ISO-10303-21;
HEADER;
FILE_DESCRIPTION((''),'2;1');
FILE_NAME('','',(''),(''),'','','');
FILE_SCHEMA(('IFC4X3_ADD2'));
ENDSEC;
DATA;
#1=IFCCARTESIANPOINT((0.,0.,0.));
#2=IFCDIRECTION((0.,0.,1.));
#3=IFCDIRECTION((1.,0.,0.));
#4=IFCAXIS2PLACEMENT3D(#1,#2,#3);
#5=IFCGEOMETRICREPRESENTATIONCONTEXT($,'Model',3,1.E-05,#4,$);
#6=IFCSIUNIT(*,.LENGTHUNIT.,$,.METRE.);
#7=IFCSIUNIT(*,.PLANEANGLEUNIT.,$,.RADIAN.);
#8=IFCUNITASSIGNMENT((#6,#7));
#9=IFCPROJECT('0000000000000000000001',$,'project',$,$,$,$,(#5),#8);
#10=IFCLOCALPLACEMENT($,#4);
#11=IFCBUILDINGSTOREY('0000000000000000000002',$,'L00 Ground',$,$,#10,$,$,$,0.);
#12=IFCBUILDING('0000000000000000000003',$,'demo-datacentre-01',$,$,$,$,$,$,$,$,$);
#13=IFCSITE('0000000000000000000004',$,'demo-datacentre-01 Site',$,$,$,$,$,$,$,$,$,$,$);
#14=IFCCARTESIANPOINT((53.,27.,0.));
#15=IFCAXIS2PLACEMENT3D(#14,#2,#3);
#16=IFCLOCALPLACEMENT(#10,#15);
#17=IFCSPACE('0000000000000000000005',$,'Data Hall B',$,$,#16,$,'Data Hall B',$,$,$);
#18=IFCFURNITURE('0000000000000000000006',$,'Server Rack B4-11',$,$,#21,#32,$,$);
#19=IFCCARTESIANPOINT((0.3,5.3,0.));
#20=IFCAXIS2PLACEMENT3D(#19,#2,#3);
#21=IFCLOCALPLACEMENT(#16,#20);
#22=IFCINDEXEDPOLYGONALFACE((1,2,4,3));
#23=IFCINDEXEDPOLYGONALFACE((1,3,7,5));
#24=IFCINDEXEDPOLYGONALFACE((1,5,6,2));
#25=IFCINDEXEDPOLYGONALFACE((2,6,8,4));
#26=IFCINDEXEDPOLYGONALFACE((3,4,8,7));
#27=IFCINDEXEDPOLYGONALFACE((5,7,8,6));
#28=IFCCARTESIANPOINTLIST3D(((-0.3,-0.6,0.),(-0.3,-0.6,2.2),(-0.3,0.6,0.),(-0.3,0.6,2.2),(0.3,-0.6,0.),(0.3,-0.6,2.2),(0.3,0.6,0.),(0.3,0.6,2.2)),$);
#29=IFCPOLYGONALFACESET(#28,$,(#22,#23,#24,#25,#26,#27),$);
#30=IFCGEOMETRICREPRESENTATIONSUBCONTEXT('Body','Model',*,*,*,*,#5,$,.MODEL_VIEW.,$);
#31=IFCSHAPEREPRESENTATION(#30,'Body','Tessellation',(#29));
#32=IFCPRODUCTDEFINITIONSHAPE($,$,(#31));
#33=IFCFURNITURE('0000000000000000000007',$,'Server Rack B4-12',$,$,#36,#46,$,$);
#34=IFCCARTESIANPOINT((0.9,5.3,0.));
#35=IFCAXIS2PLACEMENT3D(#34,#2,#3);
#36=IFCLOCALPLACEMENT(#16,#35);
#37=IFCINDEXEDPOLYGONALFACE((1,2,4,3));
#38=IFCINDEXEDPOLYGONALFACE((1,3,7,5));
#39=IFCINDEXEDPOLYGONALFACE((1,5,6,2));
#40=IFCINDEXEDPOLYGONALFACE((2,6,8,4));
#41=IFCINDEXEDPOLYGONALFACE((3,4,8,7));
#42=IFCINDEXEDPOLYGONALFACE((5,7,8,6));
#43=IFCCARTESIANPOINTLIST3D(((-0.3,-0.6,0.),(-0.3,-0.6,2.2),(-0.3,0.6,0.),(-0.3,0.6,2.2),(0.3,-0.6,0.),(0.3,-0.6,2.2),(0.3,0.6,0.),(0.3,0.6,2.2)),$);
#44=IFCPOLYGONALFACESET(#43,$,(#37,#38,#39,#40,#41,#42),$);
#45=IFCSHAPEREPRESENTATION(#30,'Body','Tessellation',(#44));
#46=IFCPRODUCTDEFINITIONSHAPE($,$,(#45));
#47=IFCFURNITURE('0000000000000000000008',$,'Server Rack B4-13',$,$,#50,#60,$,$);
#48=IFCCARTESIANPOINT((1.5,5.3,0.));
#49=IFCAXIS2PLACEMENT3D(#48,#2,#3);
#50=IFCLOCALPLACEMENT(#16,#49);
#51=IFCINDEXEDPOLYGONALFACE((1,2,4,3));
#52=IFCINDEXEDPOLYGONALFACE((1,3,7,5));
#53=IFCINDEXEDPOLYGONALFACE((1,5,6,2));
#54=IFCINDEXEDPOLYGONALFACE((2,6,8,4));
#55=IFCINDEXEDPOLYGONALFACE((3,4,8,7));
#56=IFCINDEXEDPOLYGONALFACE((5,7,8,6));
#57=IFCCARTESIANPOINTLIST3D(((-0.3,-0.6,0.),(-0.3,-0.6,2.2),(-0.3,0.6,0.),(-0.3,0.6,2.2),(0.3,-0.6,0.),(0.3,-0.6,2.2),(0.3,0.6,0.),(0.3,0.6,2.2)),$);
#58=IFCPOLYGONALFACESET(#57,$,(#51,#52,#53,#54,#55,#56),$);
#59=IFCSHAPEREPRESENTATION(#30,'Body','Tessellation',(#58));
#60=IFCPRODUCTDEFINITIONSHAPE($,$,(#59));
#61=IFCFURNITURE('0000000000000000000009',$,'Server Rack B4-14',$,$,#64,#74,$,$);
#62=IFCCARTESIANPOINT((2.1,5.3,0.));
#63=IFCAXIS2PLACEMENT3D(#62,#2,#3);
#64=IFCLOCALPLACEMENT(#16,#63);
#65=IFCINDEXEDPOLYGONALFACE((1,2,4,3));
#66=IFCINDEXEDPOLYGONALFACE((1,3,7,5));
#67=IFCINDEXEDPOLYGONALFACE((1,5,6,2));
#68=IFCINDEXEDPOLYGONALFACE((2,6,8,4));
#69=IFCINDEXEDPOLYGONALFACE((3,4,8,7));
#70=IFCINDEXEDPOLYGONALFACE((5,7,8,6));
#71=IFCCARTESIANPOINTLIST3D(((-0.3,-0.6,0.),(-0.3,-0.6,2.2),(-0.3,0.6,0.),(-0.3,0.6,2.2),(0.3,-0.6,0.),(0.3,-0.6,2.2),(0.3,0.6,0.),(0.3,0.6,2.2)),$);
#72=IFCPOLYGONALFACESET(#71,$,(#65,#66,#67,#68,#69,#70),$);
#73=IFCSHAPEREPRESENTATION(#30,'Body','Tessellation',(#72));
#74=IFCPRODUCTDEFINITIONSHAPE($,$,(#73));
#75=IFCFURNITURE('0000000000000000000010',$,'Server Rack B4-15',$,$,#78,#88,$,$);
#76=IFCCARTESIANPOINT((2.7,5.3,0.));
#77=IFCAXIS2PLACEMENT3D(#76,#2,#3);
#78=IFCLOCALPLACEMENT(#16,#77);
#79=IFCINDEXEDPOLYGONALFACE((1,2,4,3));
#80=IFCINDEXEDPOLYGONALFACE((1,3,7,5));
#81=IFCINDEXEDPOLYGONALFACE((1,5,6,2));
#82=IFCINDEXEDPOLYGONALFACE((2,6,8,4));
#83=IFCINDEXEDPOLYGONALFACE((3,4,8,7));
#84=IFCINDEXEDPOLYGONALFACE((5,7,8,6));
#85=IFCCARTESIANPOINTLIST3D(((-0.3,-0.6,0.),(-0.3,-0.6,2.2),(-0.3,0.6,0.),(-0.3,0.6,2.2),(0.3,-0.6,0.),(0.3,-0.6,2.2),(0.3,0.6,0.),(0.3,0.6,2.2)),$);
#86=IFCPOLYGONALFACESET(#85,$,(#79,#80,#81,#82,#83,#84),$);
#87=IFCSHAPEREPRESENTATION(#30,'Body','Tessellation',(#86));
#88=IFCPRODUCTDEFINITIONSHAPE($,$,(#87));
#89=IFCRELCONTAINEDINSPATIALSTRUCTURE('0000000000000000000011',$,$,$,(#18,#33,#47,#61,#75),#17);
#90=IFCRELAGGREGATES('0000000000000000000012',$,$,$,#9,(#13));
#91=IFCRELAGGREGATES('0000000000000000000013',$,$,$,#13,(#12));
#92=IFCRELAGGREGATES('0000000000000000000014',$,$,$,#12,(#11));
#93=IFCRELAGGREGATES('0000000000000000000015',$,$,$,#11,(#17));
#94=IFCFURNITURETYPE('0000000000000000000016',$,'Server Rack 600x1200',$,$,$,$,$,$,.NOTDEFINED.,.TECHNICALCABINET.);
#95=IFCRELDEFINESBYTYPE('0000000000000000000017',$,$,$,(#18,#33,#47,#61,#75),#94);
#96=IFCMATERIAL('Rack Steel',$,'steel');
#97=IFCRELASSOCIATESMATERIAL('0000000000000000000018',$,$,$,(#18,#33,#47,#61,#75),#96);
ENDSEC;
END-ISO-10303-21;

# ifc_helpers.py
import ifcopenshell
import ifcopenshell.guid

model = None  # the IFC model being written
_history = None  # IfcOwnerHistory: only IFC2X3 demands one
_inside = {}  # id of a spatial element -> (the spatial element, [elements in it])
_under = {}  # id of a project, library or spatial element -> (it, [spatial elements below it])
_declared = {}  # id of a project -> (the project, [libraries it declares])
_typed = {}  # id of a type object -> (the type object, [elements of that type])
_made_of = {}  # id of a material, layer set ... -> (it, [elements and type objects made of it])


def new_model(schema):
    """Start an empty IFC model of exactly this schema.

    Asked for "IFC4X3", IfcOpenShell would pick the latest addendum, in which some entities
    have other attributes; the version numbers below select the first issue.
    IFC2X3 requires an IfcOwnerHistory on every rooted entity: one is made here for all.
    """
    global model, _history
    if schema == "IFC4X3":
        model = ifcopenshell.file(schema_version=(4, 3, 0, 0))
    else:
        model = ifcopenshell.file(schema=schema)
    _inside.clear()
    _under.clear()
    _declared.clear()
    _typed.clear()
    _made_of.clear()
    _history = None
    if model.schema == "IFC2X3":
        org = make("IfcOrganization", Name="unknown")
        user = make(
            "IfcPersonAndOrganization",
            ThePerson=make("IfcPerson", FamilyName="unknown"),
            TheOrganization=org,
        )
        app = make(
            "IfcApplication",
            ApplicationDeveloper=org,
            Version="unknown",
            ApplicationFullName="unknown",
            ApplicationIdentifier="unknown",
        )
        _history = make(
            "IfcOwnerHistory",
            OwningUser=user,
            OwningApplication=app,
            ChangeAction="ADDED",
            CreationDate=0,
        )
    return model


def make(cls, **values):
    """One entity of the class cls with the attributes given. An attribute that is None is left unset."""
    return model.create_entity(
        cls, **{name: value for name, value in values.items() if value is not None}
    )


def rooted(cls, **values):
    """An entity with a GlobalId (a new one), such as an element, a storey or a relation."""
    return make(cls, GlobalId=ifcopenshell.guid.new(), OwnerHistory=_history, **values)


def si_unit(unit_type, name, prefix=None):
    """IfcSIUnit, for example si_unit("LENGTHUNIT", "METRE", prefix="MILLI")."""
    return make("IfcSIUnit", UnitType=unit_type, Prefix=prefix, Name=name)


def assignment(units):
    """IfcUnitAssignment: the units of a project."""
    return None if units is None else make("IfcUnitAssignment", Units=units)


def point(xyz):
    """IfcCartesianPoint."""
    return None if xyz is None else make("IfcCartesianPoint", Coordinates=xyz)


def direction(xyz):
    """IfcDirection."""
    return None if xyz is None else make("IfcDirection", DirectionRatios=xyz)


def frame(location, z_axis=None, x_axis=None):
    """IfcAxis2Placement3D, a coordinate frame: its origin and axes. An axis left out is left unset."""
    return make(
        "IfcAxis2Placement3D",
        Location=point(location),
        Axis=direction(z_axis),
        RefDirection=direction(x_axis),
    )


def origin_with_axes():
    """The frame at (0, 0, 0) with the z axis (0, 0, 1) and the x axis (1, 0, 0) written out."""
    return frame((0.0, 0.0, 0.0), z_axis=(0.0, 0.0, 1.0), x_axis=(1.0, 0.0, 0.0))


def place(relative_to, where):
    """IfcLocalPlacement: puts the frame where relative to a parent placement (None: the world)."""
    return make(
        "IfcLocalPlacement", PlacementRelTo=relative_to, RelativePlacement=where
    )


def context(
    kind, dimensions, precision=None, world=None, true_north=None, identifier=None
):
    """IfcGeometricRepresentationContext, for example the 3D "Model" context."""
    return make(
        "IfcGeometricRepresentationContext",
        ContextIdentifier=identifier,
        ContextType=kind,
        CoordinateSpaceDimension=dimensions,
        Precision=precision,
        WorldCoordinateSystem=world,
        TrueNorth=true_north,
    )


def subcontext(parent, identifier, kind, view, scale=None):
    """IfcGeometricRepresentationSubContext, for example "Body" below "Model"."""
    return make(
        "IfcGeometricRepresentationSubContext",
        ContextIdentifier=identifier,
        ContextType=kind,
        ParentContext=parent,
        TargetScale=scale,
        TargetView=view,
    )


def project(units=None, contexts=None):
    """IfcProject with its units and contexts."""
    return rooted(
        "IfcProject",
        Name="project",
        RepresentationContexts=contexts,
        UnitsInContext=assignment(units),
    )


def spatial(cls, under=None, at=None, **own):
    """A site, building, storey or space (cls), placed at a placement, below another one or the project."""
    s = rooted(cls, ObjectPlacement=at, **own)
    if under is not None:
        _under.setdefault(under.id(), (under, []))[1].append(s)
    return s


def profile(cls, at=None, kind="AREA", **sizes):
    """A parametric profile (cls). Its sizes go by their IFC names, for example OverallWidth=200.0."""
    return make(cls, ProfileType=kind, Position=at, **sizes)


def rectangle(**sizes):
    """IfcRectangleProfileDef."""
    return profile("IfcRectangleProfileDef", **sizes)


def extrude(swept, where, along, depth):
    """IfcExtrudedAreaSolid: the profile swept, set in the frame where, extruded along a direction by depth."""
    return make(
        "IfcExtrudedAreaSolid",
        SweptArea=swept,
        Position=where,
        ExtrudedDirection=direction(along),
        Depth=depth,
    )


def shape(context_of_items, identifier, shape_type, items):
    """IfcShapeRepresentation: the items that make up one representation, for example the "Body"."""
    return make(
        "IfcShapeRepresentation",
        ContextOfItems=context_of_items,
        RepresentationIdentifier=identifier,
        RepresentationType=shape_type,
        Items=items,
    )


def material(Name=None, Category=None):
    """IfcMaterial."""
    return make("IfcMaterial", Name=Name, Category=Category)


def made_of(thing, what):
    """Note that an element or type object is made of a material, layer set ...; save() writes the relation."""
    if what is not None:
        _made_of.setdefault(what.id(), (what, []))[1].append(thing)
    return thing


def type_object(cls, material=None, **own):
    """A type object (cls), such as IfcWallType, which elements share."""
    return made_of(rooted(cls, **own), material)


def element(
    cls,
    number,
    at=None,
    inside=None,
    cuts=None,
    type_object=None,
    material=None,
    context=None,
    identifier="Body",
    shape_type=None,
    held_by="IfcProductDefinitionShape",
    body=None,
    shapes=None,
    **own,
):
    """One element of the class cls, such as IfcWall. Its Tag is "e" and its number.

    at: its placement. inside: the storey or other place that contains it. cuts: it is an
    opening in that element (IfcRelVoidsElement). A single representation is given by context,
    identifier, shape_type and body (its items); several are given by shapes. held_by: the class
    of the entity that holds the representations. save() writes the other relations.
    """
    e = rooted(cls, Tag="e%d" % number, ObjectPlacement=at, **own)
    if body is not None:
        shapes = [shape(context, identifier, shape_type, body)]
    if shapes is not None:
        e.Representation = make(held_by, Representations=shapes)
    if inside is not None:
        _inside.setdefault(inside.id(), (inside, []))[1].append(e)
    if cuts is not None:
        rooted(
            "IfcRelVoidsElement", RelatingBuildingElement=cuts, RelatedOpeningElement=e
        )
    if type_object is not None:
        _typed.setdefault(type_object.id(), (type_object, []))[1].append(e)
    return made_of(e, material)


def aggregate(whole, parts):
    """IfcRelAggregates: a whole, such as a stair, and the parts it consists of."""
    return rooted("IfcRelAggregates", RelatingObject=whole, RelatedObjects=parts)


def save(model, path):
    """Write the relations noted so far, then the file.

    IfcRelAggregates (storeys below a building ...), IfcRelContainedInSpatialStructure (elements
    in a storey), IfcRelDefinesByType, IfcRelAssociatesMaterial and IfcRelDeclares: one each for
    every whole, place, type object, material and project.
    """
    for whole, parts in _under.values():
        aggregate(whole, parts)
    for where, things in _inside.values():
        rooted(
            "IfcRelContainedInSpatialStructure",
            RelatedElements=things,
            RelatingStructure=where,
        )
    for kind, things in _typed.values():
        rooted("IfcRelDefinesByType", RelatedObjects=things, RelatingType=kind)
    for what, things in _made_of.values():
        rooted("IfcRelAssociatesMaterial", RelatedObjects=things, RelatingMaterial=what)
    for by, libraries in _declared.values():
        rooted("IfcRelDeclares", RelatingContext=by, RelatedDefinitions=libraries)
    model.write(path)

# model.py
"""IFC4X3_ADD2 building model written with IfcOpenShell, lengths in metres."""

from ifc_helpers import new_model, si_unit, frame, origin_with_axes, place, context, subcontext, project, spatial, rectangle, extrude, material, type_object, element, save


model = new_model("IFC4X3_ADD2")

# Units and contexts
model_context = context("Model", 3, precision=1e-05, world=origin_with_axes())
body_context = subcontext(model_context, "Body", "Model", "MODEL_VIEW")
ifc_project = project(units=[si_unit("LENGTHUNIT", "METRE"), si_unit("PLANEANGLEUNIT", "RADIAN")], contexts=[model_context])

# Site, building, storey
site = spatial("IfcSite", under=ifc_project, Name="demo-datacentre-01 Site")
building = spatial("IfcBuilding", under=site, Name="demo-datacentre-01")
storey_placement = place(None, origin_with_axes())
storey = spatial("IfcBuildingStorey", under=building, at=storey_placement, Name="L00 Ground", Elevation=0.0)

# Shared definitions
space_placement = place(storey_placement, frame((53.0, 27.0, 0.0), z_axis=(0.0, 0.0, 1.0), x_axis=(1.0, 0.0, 0.0)))
space = spatial("IfcSpace", under=storey, at=space_placement, Name="Data Hall B", LongName="Data Hall B")

# Furniture
ifc_material_1 = material(Name="Rack Steel", Category="steel")
furniture_type = type_object("IfcFurnitureType", Name="Server Rack 600x1200", AssemblyPlace="NOTDEFINED", PredefinedType="TECHNICALCABINET")
for number, where, z_axis, x_axis, name in (
    (1, (0.3, 5.3, 0.0), (0.0, 0.0, 1.0), (1.0, 0.0, 0.0), "Server Rack B4-11"),
    (2, (0.9, 5.3, 0.0), (0.0, 0.0, 1.0), (1.0, 0.0, 0.0), "Server Rack B4-12"),
    (3, (1.5, 5.3, 0.0), (0.0, 0.0, 1.0), (1.0, 0.0, 0.0), "Server Rack B4-13"),
    (4, (2.1, 5.3, 0.0), (0.0, 0.0, 1.0), (1.0, 0.0, 0.0), "Server Rack B4-14"),
    (5, (2.7, 5.3, 0.0), (0.0, 0.0, 1.0), (1.0, 0.0, 0.0), "Server Rack B4-15"),
):
    element("IfcFurniture", number, at=place(space_placement, frame(where, z_axis=z_axis, x_axis=x_axis)), inside=space, type_object=furniture_type, material=ifc_material_1, Name=name, context=body_context, shape_type="SweptSolid", body=[
        extrude(rectangle(XDim=0.6, YDim=1.2), origin_with_axes(), (0.0, 0.0, 1.0), 2.2),
    ])

save(model, "model.ifc")
